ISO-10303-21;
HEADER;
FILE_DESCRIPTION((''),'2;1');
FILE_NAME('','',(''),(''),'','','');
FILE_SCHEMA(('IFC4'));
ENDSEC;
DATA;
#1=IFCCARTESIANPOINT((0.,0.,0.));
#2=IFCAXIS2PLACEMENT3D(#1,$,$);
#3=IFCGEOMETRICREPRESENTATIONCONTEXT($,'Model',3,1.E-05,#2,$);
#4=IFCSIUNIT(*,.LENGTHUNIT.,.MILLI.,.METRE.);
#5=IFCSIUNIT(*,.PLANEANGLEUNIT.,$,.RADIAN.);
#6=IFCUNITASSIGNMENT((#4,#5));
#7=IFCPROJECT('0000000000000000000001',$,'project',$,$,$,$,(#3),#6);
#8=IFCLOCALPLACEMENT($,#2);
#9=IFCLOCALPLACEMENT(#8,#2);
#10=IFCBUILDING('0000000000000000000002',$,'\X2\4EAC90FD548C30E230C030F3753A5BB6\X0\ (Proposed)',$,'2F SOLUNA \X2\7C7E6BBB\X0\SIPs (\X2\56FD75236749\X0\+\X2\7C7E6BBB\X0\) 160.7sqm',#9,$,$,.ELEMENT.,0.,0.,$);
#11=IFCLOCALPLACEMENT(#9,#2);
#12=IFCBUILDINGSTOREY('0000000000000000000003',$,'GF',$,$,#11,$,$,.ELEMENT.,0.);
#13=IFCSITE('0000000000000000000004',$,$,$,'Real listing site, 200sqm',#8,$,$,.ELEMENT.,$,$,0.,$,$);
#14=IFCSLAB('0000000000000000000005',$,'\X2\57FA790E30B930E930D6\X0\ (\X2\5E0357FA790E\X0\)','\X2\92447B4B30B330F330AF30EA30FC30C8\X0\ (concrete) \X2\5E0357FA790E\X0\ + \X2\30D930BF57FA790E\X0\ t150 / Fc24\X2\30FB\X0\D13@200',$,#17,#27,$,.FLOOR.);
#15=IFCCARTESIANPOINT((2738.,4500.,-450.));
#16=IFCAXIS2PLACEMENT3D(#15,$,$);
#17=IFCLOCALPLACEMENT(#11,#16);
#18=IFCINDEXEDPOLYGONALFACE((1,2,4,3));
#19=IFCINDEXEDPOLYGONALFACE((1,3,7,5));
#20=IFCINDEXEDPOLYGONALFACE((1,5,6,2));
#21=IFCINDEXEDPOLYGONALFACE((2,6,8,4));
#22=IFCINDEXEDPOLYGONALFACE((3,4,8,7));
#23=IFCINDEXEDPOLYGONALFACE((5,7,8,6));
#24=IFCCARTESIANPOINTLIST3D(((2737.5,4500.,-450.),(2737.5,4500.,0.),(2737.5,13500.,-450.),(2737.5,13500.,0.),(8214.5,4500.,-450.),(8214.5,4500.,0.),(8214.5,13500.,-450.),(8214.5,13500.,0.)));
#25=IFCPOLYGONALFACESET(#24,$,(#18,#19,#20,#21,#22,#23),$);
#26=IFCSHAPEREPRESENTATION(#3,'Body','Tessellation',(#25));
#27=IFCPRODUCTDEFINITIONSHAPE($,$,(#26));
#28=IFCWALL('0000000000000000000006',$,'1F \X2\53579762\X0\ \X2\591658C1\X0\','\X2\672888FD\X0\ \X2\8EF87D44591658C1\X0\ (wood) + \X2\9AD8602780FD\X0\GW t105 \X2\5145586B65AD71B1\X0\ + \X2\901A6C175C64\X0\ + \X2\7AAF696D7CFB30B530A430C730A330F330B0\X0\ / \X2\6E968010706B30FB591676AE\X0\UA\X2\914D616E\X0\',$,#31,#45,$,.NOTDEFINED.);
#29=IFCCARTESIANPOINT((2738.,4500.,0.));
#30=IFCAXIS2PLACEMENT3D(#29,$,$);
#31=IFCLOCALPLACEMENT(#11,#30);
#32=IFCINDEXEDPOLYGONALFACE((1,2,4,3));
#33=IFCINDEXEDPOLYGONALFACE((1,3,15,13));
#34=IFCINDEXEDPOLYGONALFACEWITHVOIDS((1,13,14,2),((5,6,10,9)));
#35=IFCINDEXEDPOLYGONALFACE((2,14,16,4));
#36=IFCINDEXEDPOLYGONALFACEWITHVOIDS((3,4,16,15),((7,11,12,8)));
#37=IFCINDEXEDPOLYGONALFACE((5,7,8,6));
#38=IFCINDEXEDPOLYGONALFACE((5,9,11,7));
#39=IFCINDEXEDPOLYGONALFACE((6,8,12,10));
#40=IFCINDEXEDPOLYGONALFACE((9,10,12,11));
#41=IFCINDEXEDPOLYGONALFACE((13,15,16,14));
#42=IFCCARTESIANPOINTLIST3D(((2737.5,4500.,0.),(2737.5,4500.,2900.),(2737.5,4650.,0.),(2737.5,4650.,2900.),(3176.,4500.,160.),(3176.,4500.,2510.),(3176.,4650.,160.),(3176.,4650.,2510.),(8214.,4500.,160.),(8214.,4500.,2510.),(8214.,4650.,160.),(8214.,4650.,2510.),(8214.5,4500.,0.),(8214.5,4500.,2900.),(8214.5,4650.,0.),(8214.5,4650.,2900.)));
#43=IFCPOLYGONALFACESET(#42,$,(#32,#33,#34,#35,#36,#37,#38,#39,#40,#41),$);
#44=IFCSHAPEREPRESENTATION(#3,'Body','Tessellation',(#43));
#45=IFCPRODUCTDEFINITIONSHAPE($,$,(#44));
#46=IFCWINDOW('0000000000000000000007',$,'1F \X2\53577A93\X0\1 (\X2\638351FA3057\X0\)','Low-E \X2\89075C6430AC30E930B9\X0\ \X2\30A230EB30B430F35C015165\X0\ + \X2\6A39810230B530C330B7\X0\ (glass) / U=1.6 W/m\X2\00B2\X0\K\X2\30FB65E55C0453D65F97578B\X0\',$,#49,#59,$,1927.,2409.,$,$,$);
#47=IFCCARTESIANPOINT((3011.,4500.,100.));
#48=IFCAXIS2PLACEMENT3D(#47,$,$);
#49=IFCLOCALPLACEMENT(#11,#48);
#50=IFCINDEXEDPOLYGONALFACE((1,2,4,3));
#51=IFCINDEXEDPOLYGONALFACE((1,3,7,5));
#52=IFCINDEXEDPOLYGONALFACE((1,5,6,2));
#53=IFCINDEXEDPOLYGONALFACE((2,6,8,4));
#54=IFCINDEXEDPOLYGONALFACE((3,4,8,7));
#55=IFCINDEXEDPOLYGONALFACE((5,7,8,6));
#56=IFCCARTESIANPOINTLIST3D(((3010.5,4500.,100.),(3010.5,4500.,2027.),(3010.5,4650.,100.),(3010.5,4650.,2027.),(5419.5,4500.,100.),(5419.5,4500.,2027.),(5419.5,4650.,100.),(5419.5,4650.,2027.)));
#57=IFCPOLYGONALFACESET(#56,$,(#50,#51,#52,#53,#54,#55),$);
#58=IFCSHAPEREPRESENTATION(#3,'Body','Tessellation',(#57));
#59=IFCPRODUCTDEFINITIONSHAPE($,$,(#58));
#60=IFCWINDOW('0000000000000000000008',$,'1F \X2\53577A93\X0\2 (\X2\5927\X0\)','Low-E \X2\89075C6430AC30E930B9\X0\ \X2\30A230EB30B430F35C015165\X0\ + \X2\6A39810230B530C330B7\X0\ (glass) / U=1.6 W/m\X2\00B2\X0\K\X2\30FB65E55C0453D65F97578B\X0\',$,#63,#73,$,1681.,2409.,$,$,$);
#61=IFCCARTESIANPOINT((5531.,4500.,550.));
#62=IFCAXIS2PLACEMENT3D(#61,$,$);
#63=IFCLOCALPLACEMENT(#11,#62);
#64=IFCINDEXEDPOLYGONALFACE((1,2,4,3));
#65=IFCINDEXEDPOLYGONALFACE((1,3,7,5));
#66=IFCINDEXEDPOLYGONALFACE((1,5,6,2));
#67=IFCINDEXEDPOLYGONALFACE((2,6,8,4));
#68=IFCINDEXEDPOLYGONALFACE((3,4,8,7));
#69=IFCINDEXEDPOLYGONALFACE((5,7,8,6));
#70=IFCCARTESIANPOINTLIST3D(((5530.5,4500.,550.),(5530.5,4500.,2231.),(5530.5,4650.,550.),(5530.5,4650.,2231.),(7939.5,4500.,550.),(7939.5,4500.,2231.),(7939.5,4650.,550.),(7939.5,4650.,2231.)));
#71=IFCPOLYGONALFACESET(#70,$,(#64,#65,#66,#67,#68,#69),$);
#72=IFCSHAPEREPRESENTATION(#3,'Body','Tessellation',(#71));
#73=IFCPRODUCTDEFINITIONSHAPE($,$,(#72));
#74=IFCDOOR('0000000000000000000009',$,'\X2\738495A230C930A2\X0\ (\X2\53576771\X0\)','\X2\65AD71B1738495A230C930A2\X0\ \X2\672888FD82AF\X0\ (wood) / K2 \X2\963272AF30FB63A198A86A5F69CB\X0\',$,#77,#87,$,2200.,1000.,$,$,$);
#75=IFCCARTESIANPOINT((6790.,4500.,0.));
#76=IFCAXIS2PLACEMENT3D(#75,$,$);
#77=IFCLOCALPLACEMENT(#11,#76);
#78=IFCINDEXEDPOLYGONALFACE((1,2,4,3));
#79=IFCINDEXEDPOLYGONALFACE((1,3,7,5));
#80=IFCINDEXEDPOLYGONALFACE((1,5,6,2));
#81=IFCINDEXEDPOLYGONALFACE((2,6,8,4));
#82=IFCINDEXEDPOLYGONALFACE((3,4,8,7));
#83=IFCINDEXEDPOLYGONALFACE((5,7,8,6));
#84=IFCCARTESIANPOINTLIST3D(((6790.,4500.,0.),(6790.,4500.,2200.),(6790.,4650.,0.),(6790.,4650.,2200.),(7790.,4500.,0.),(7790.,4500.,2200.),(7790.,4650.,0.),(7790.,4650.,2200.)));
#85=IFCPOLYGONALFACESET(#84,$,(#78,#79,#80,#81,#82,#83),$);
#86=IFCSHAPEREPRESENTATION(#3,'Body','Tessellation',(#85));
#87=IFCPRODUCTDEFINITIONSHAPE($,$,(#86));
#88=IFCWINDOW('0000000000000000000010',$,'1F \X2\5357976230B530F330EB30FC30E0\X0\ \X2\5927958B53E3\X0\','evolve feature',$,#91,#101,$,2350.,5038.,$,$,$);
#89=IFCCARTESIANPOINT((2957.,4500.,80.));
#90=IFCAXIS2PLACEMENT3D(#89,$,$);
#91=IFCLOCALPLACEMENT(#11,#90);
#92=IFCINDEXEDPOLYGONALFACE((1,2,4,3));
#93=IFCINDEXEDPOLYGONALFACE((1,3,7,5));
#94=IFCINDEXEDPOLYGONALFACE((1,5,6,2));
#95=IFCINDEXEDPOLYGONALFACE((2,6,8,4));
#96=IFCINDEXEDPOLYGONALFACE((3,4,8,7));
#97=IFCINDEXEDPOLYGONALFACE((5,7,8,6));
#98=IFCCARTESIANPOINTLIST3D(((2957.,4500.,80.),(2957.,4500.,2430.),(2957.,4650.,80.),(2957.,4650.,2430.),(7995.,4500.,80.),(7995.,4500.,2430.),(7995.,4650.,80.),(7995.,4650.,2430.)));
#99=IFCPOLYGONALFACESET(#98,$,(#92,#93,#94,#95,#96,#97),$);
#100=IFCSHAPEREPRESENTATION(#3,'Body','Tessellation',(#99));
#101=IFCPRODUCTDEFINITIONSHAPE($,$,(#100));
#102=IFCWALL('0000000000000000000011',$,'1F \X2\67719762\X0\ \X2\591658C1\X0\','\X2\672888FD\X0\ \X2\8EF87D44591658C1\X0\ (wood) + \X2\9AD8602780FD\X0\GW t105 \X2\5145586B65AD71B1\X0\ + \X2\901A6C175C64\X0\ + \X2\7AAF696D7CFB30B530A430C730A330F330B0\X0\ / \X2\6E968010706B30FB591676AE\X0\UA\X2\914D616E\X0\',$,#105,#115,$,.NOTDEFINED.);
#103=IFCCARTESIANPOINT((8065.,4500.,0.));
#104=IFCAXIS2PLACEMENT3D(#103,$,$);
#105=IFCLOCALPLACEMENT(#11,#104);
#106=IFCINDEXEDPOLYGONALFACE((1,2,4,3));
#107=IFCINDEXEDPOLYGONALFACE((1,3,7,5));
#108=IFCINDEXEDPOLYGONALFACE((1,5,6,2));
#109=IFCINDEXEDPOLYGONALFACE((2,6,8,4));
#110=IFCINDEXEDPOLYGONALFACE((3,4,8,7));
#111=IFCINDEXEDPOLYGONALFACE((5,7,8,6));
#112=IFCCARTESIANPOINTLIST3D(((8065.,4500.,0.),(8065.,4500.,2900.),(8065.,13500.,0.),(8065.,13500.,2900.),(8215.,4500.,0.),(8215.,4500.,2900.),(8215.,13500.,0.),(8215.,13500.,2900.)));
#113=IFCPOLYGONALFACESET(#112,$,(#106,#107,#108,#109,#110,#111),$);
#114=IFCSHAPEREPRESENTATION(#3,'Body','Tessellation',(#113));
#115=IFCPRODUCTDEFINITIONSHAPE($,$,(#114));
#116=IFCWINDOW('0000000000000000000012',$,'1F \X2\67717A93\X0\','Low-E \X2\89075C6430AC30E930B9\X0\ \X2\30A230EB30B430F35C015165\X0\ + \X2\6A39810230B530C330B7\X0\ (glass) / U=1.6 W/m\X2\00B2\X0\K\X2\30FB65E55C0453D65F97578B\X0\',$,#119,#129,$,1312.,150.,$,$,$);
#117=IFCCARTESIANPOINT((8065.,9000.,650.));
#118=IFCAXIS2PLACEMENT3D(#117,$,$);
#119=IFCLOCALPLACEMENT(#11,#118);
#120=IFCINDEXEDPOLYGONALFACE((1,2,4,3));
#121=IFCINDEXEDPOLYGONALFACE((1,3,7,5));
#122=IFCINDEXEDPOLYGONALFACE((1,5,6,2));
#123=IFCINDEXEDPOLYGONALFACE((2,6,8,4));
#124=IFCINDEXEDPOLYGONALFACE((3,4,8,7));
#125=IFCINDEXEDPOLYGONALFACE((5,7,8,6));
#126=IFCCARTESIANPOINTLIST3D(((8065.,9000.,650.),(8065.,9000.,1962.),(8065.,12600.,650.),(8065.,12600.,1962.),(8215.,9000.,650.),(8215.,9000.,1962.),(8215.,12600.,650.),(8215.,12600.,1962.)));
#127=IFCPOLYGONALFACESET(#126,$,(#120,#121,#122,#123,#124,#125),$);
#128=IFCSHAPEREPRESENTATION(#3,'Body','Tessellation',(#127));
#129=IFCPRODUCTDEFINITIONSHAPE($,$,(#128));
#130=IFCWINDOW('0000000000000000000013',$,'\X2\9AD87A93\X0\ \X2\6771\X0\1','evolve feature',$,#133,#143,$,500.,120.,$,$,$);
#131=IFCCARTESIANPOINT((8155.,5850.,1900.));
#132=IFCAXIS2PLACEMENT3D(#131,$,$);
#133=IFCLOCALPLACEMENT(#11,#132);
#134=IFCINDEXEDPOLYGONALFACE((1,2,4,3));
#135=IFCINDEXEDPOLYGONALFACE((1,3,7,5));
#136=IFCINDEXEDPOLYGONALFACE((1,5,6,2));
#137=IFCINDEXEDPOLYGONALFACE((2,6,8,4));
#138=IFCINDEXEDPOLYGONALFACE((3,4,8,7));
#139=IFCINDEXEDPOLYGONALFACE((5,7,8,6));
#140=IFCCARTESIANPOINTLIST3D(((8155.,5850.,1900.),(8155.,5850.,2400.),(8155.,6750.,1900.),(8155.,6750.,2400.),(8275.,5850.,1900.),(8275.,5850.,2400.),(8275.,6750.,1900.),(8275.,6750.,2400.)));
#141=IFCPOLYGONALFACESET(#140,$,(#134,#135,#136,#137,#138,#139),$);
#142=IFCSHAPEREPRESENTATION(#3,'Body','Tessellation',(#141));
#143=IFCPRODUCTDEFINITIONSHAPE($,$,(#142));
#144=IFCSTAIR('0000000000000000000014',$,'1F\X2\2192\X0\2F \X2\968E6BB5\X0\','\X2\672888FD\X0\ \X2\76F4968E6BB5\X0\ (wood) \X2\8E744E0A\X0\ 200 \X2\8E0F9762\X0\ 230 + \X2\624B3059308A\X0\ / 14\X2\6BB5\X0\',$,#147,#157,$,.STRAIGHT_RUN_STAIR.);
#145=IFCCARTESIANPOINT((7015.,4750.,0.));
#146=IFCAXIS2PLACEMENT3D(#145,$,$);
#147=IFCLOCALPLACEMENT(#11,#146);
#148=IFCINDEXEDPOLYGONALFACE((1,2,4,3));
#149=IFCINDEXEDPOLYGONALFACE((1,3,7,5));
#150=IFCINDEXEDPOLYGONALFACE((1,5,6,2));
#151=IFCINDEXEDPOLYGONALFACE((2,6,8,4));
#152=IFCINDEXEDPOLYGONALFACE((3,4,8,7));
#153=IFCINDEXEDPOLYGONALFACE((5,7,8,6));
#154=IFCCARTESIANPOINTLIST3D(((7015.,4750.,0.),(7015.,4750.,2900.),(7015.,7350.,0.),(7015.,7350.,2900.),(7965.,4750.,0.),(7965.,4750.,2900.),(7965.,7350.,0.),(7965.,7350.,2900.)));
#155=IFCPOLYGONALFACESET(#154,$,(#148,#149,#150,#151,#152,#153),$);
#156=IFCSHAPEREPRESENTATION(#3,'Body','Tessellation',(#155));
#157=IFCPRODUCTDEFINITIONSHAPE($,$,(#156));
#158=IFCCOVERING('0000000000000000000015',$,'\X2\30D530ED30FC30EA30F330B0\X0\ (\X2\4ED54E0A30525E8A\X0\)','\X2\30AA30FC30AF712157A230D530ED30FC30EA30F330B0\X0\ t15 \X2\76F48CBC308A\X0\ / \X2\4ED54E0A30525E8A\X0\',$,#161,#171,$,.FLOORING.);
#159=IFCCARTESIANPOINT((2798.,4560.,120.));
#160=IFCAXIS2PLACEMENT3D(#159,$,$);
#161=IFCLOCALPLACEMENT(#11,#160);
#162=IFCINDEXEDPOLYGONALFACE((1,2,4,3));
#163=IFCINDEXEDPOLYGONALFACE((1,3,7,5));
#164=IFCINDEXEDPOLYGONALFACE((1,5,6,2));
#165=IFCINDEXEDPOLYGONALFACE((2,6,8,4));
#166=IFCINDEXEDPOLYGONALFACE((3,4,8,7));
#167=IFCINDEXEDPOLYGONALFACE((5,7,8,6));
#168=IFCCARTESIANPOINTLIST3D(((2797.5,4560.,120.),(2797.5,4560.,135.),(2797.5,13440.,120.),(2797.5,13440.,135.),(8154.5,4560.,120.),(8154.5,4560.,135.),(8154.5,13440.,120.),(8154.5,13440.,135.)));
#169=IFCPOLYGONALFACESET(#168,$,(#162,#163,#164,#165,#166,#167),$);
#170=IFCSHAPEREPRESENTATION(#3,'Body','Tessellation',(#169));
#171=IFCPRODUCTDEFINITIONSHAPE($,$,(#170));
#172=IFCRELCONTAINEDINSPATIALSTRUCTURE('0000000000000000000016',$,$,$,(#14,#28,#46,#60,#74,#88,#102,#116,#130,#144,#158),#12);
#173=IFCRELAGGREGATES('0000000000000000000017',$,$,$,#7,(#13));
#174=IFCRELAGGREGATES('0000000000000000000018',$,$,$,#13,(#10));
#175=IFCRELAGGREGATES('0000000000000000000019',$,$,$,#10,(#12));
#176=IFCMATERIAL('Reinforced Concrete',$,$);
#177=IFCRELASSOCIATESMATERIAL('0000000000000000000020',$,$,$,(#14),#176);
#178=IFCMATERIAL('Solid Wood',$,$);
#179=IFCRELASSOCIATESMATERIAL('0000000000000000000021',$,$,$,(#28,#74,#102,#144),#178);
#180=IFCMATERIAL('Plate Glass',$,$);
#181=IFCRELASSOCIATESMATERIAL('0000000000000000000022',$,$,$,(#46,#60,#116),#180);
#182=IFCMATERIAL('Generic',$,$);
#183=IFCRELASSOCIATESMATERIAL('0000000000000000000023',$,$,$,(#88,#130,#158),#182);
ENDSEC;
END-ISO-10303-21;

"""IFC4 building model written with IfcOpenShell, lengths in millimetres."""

from ifc_helpers import new_model, si_unit, frame, frame_2d, origin, place, context, project, spatial, rectangle, extrude, material, element, fill, save


model = new_model("IFC4")

# Units and contexts
model_context = context("Model", 3, precision=1e-05, world=origin())
ifc_project = project(units=[si_unit("LENGTHUNIT", "METRE", prefix="MILLI"), si_unit("PLANEANGLEUNIT", "RADIAN")], contexts=[model_context])

# Site, building, storey
site_placement = place(None, origin())
site = spatial("IfcSite", under=ifc_project, at=site_placement, ObjectType="Real listing site, 200sqm", CompositionType="ELEMENT", RefElevation=0.0)
building_placement = place(site_placement, origin())
building = spatial("IfcBuilding", under=site, at=building_placement, Name="京都和モダン町家 (Proposed)", ObjectType="2F SOLUNA 籾殻SIPs (国産杉+籾殻) 160.7sqm", CompositionType="ELEMENT", ElevationOfRefHeight=0.0, ElevationOfTerrain=0.0)
storey_placement = place(building_placement, origin())
storey = spatial("IfcBuildingStorey", under=building, at=storey_placement, Name="GF", CompositionType="ELEMENT", Elevation=0.0)

# Slab
ifc_material_1 = material(Name="Reinforced Concrete")
slab_1_placement = place(storey_placement, frame((2738.0, 4500.0, -450.0)))
element("IfcSlab", 1, at=slab_1_placement, inside=storey, material=ifc_material_1, Name="基礎スラブ (布基礎)", Description="鉄筋コンクリート (concrete) 布基礎 + ベタ基礎 t150 / Fc24・D13@200", PredefinedType="FLOOR", context=model_context, shape_type="SweptSolid", body=[
    extrude(rectangle(XDim=5477.0, YDim=9000.0, at=frame_2d((2738.0, 4500.0))), frame((2738.0, 4500.0, -450.0)), (0.0, 0.0, 1.0), 450.0),
])
ifc_material_2 = material(Name="Solid Wood")
ifc_material_3 = material(Name="Generic")

# Wall, openings, windows, door
wall_1_placement = place(storey_placement, frame((2738.0, 4500.0, 0.0)))
wall_1 = element("IfcWall", 2, at=wall_1_placement, inside=storey, material=ifc_material_2, Name="1F 南面 外壁", Description="木製 軸組外壁 (wood) + 高性能GW t105 充填断熱 + 通気層 + 窯業系サイディング / 準耐火・外皮UA配慮", PredefinedType="NOTDEFINED", context=model_context, shape_type="SweptSolid", body=[
    extrude(rectangle(XDim=5477.0, YDim=150.0, at=frame_2d((2738.0, 75.0))), frame((2738.0, 4500.0, 0.0)), (0.0, 0.0, 1.0), 2900.0),
])
opening_1_placement = place(storey_placement, frame((3011.0, 4500.0, 100.0)))
opening_1 = element("IfcOpeningElement", 3, at=opening_1_placement, cuts=wall_1, PredefinedType="NOTDEFINED", context=model_context, shape_type="SweptSolid", body=[
    extrude(rectangle(XDim=2409.0, YDim=150.0, at=frame_2d((1204.0, 75.0))), frame((3011.0, 4500.0, 100.0)), (0.0, 0.0, 1.0), 1927.0),
])
opening_2_placement = place(storey_placement, frame((5531.0, 4500.0, 550.0)))
opening_2 = element("IfcOpeningElement", 4, at=opening_2_placement, cuts=wall_1, PredefinedType="NOTDEFINED", context=model_context, shape_type="SweptSolid", body=[
    extrude(rectangle(XDim=2409.0, YDim=150.0, at=frame_2d((1204.0, 75.0))), frame((5531.0, 4500.0, 550.0)), (0.0, 0.0, 1.0), 1681.0),
])
opening_3_placement = place(storey_placement, frame((6790.0, 4500.0, 0.0)))
opening_3 = element("IfcOpeningElement", 5, at=opening_3_placement, cuts=wall_1, PredefinedType="NOTDEFINED", context=model_context, shape_type="SweptSolid", body=[
    extrude(rectangle(XDim=1000.0, YDim=150.0, at=frame_2d((500.0, 75.0))), frame((6790.0, 4500.0, 0.0)), (0.0, 0.0, 1.0), 2200.0),
])
opening_4_placement = place(storey_placement, frame((2957.0, 4500.0, 80.0)))
opening_4 = element("IfcOpeningElement", 6, at=opening_4_placement, cuts=wall_1, PredefinedType="NOTDEFINED", context=model_context, shape_type="SweptSolid", body=[
    extrude(rectangle(XDim=5038.0, YDim=150.0, at=frame_2d((2519.0, 75.0))), frame((2957.0, 4500.0, 80.0)), (0.0, 0.0, 1.0), 2350.0),
])
ifc_material_4 = material(Name="Plate Glass")
window_1_placement = place(storey_placement, frame((3011.0, 4500.0, 100.0)))
window_1 = element("IfcWindow", 7, at=window_1_placement, inside=storey, material=ifc_material_4, Name="1F 南窓1 (掃出し)", Description="Low-E 複層ガラス アルゴン封入 + 樹脂サッシ (glass) / U=1.6 W/m²K・日射取得型", OverallHeight=1927.0, OverallWidth=2409.0, context=model_context, shape_type="SweptSolid", body=[
    extrude(rectangle(XDim=2409.0, YDim=150.0, at=frame_2d((1204.0, 75.0))), frame((3011.0, 4500.0, 100.0)), (0.0, 0.0, 1.0), 1927.0),
])
fill(opening_1, window_1)
window_2_placement = place(storey_placement, frame((5531.0, 4500.0, 550.0)))
window_2 = element("IfcWindow", 8, at=window_2_placement, inside=storey, material=ifc_material_4, Name="1F 南窓2 (大)", Description="Low-E 複層ガラス アルゴン封入 + 樹脂サッシ (glass) / U=1.6 W/m²K・日射取得型", OverallHeight=1681.0, OverallWidth=2409.0, context=model_context, shape_type="SweptSolid", body=[
    extrude(rectangle(XDim=2409.0, YDim=150.0, at=frame_2d((1204.0, 75.0))), frame((5531.0, 4500.0, 550.0)), (0.0, 0.0, 1.0), 1681.0),
])
fill(opening_2, window_2)
door_placement = place(storey_placement, frame((6790.0, 4500.0, 0.0)))
door = element("IfcDoor", 9, at=door_placement, inside=storey, material=ifc_material_2, Name="玄関ドア (南東)", Description="断熱玄関ドア 木製芯 (wood) / K2 防犯・採風機構", OverallHeight=2200.0, OverallWidth=1000.0, context=model_context, shape_type="SweptSolid", body=[
    extrude(rectangle(XDim=1000.0, YDim=150.0, at=frame_2d((500.0, 75.0))), frame((6790.0, 4500.0, 0.0)), (0.0, 0.0, 1.0), 2200.0),
])
fill(opening_3, door)
window_3_placement = place(storey_placement, frame((2957.0, 4500.0, 80.0)))
window_3 = element("IfcWindow", 10, at=window_3_placement, inside=storey, material=ifc_material_3, Name="1F 南面サンルーム 大開口", Description="evolve feature", OverallHeight=2350.0, OverallWidth=5038.0, context=model_context, shape_type="SweptSolid", body=[
    extrude(rectangle(XDim=5038.0, YDim=150.0, at=frame_2d((2519.0, 75.0))), frame((2957.0, 4500.0, 80.0)), (0.0, 0.0, 1.0), 2350.0),
])
fill(opening_4, window_3)

# Wall, openings, windows
wall_2_placement = place(storey_placement, frame((8065.0, 4500.0, 0.0)))
wall_2 = element("IfcWall", 11, at=wall_2_placement, inside=storey, material=ifc_material_2, Name="1F 東面 外壁", Description="木製 軸組外壁 (wood) + 高性能GW t105 充填断熱 + 通気層 + 窯業系サイディング / 準耐火・外皮UA配慮", PredefinedType="NOTDEFINED", context=model_context, shape_type="SweptSolid", body=[
    extrude(rectangle(XDim=150.0, YDim=9000.0, at=frame_2d((75.0, 4500.0))), frame((8065.0, 4500.0, 0.0)), (0.0, 0.0, 1.0), 2900.0),
])
opening_5_placement = place(storey_placement, frame((8065.0, 9000.0, 650.0)))
opening_5 = element("IfcOpeningElement", 12, at=opening_5_placement, cuts=wall_2, PredefinedType="NOTDEFINED", context=model_context, shape_type="SweptSolid", body=[
    extrude(rectangle(XDim=150.0, YDim=3600.0, at=frame_2d((75.0, 1800.0))), frame((8065.0, 9000.0, 650.0)), (0.0, 0.0, 1.0), 1312.0),
])
opening_6_placement = place(storey_placement, frame((8155.0, 5850.0, 1900.0)))
opening_6 = element("IfcOpeningElement", 13, at=opening_6_placement, cuts=wall_2, PredefinedType="NOTDEFINED", context=model_context, shape_type="SweptSolid", body=[
    extrude(rectangle(XDim=120.0, YDim=900.0, at=frame_2d((60.0, 450.0))), frame((8155.0, 5850.0, 1900.0)), (0.0, 0.0, 1.0), 500.0),
])
window_4_placement = place(storey_placement, frame((8065.0, 9000.0, 650.0)))
window_4 = element("IfcWindow", 14, at=window_4_placement, inside=storey, material=ifc_material_4, Name="1F 東窓", Description="Low-E 複層ガラス アルゴン封入 + 樹脂サッシ (glass) / U=1.6 W/m²K・日射取得型", OverallHeight=1312.0, OverallWidth=150.0, context=model_context, shape_type="SweptSolid", body=[
    extrude(rectangle(XDim=150.0, YDim=3600.0, at=frame_2d((75.0, 1800.0))), frame((8065.0, 9000.0, 650.0)), (0.0, 0.0, 1.0), 1312.0),
])
fill(opening_5, window_4)
window_5_placement = place(storey_placement, frame((8155.0, 5850.0, 1900.0)))
window_5 = element("IfcWindow", 15, at=window_5_placement, inside=storey, material=ifc_material_3, Name="高窓 東1", Description="evolve feature", OverallHeight=500.0, OverallWidth=120.0, context=model_context, shape_type="SweptSolid", body=[
    extrude(rectangle(XDim=120.0, YDim=900.0, at=frame_2d((60.0, 450.0))), frame((8155.0, 5850.0, 1900.0)), (0.0, 0.0, 1.0), 500.0),
])
fill(opening_6, window_5)

# Stair
stair_placement = place(storey_placement, frame((7015.0, 4750.0, 0.0)))
element("IfcStair", 16, at=stair_placement, inside=storey, material=ifc_material_2, Name="1F→2F 階段", Description="木製 直階段 (wood) 蹴上 200 踏面 230 + 手すり / 14段", PredefinedType="STRAIGHT_RUN_STAIR", context=model_context, shape_type="SweptSolid", body=[
    extrude(rectangle(XDim=950.0, YDim=2600.0, at=frame_2d((475.0, 1300.0))), frame((7015.0, 4750.0, 0.0)), (0.0, 0.0, 1.0), 2900.0),
])

# Covering
covering_placement = place(storey_placement, frame((2798.0, 4560.0, 120.0)))
element("IfcCovering", 17, at=covering_placement, inside=storey, material=ifc_material_3, Name="フローリング (仕上げ床)", Description="オーク無垢フローリング t15 直貼り / 仕上げ床", PredefinedType="FLOORING", context=model_context, shape_type="SweptSolid", body=[
    extrude(rectangle(XDim=5357.0, YDim=8880.0, at=frame_2d((2678.0, 4440.0))), frame((2798.0, 4560.0, 120.0)), (0.0, 0.0, 1.0), 15.0),
])

save(model, "model.ifc")
